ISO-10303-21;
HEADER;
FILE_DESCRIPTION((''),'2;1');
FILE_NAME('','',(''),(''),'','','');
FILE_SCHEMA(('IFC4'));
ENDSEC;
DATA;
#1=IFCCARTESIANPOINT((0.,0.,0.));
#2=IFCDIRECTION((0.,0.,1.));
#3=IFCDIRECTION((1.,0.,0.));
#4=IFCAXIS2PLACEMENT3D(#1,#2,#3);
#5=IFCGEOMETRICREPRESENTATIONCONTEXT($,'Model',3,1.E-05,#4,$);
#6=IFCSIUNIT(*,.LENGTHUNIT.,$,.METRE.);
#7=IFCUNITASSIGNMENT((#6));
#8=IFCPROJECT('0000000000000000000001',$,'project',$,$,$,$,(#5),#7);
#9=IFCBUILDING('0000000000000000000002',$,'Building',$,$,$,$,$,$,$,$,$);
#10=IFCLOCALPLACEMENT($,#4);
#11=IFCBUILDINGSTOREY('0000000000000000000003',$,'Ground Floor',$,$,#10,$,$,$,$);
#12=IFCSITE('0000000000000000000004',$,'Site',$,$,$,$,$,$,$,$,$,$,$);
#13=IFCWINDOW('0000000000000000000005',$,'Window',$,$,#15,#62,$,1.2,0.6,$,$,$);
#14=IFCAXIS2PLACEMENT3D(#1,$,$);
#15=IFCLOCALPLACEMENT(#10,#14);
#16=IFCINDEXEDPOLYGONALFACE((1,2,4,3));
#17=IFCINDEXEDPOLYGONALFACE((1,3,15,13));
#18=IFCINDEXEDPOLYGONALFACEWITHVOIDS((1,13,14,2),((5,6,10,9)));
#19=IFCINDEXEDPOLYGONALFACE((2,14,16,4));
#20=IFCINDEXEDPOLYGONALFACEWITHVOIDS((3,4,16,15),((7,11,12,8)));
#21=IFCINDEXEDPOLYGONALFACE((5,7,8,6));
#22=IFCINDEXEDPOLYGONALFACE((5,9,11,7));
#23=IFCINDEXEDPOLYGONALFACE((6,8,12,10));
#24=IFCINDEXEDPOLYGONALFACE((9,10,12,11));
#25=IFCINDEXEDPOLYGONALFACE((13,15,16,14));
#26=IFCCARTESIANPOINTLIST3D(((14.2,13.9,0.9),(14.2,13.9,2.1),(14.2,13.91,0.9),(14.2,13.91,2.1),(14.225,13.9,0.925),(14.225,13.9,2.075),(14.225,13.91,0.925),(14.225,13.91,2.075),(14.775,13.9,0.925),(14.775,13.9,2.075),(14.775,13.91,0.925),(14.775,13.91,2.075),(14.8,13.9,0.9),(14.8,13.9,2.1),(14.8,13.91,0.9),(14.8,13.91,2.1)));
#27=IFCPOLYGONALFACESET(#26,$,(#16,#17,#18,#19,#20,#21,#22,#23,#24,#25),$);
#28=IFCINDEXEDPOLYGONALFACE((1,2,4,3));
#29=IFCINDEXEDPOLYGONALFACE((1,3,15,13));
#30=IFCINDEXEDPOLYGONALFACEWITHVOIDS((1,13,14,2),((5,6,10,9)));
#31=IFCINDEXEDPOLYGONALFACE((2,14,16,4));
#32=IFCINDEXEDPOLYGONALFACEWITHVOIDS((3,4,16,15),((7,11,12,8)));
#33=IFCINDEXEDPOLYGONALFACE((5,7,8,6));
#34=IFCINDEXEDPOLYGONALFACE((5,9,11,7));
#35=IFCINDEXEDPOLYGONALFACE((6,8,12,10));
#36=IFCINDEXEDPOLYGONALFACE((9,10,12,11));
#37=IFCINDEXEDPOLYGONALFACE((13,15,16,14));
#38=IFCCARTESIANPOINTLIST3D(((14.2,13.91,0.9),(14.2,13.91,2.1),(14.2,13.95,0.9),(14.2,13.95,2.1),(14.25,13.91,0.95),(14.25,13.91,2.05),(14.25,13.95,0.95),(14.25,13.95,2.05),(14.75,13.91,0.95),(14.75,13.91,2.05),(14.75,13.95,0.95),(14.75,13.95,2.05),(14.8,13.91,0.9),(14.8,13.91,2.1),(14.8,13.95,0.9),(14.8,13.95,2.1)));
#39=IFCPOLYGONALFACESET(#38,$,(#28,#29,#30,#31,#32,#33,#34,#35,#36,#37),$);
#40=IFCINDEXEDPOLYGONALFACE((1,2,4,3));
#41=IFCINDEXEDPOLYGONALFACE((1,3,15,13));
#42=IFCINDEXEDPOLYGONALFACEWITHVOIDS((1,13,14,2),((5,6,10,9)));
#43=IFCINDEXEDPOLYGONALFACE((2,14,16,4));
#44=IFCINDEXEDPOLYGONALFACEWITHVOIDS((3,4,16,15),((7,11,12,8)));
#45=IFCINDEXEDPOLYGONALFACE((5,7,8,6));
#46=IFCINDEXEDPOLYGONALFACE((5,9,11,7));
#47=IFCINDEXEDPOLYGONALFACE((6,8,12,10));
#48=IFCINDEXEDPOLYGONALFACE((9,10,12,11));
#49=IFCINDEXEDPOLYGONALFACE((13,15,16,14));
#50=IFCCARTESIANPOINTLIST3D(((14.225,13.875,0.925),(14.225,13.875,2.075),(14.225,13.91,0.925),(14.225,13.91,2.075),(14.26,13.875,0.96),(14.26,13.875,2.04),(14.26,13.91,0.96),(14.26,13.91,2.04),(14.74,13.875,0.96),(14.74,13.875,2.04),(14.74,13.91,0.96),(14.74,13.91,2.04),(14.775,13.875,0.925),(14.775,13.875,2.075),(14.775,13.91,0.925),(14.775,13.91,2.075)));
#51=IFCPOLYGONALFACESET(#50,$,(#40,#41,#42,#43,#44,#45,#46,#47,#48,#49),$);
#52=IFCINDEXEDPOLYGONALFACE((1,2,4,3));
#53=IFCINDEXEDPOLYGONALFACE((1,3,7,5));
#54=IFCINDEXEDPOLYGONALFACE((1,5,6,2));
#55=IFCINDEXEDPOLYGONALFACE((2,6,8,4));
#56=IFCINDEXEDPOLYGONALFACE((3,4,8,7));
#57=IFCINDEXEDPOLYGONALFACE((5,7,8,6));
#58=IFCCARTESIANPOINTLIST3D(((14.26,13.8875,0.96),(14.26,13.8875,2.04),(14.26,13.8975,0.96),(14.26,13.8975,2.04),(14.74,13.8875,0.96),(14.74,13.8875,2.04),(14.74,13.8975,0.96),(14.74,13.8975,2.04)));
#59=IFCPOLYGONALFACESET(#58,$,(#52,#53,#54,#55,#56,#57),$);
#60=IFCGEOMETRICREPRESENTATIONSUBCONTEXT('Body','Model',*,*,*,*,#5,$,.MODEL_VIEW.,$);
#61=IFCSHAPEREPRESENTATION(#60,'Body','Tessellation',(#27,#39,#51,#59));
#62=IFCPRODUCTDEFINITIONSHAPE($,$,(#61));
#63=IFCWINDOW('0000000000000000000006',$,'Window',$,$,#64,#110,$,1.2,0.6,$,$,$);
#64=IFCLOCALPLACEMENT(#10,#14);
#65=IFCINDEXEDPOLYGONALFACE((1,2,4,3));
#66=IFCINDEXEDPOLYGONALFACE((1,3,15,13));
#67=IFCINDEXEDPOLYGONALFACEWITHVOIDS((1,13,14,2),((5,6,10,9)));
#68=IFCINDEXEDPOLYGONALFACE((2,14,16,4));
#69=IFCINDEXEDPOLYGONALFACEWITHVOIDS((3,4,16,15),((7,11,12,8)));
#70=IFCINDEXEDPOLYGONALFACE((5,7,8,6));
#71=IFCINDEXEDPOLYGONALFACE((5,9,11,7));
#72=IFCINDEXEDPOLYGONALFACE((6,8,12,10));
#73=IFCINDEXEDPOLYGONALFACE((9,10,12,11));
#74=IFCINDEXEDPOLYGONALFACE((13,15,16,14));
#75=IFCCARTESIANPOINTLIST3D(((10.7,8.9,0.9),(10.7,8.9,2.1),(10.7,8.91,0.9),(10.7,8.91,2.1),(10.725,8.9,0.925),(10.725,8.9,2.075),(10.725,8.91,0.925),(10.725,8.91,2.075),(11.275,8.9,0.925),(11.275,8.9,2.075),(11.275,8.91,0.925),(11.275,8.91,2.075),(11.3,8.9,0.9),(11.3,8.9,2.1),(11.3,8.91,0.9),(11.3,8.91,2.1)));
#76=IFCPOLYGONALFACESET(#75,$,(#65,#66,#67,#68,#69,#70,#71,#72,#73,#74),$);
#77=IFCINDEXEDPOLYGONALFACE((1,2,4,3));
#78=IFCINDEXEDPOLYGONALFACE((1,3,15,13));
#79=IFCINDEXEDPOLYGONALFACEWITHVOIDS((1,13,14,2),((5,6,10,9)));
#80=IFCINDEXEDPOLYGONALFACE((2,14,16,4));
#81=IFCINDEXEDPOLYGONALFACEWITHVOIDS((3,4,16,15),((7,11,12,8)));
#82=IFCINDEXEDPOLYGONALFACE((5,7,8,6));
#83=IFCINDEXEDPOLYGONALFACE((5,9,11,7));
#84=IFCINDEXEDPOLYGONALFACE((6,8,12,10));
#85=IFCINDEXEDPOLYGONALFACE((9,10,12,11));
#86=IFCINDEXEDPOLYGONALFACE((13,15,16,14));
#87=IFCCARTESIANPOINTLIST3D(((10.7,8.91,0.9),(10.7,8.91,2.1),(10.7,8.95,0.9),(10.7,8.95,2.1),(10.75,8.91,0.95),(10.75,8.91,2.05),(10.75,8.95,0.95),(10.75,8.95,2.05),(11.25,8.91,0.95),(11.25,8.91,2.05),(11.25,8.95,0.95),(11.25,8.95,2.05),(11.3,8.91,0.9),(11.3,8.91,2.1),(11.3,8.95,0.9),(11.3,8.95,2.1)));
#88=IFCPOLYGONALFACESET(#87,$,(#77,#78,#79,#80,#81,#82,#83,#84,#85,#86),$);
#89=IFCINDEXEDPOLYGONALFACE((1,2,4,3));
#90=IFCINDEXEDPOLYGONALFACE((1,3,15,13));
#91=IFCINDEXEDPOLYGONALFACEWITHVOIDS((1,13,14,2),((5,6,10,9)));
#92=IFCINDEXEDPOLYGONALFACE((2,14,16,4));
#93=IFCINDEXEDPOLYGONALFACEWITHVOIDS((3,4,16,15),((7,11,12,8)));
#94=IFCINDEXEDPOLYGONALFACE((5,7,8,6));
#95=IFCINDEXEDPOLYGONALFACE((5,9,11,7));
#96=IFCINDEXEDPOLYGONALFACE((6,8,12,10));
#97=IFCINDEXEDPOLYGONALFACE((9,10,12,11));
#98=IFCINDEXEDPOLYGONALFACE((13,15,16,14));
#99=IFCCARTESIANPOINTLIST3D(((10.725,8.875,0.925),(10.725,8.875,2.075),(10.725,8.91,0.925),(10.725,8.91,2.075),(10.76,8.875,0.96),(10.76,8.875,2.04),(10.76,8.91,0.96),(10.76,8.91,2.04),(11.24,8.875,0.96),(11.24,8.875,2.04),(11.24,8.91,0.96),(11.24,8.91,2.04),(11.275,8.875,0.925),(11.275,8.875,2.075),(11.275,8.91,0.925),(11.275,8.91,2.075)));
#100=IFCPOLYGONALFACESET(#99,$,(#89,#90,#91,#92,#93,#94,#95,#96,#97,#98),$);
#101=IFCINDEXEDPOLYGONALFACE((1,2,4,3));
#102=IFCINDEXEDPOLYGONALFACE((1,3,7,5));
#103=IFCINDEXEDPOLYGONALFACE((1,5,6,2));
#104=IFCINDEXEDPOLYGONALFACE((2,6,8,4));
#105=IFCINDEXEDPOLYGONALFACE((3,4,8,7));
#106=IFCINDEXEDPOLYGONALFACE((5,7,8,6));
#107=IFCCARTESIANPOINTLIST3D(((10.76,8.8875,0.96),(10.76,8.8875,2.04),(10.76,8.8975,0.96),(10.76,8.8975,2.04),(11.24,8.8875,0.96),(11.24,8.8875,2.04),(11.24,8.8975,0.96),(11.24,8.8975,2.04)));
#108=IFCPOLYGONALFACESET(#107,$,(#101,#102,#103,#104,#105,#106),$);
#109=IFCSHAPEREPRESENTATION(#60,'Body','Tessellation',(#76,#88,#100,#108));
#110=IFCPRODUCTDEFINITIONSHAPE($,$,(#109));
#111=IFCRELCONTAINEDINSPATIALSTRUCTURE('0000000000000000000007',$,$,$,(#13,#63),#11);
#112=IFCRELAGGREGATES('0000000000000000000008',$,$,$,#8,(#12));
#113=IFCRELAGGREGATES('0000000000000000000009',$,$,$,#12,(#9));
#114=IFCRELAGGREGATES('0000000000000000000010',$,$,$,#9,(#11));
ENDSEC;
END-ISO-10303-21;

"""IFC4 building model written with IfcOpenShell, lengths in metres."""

from ifc_helpers import new_model, si_unit, frame, origin_with_axes, place, context, subcontext, project, spatial, line, indexed_curve, outline, extrude, element, save


model = new_model("IFC4")

# Units and contexts
model_context = context("Model", 3, precision=1e-05, world=origin_with_axes())
body_context = subcontext(model_context, "Body", "Model", "MODEL_VIEW")
ifc_project = project(units=[si_unit("LENGTHUNIT", "METRE")], contexts=[model_context])

# Site, building, storey
site = spatial("IfcSite", under=ifc_project, Name="Site")
building = spatial("IfcBuilding", under=site, Name="Building")
storey_placement = place(None, origin_with_axes())
storey = spatial("IfcBuildingStorey", under=building, at=storey_placement, Name="Ground Floor")

# Windows
for number, where, z_axis, x_axis, name in (
    (1, (14.8, 14.0, 0.9), (0.0, 0.0, 1.0), (-1.0, 0.0, 0.0), "Window"),
    (2, (11.3, 9.0, 0.9), (0.0, 0.0, 1.0), (-1.0, 0.0, 0.0), "Window"),
):
    element("IfcWindow", number, at=place(storey_placement, frame(where, z_axis=z_axis, x_axis=x_axis)), inside=storey, Name=name, OverallHeight=1.2, OverallWidth=0.6, context=body_context, shape_type="SweptSolid", body=[
        extrude(outline(indexed_curve([(0.0, 0.0), (0.6, 0.0), (0.6, 1.2), (0.0, 1.2)], segments=[line(1, 2, 3, 4, 1)]), holes=[indexed_curve([(0.025, 0.025), (0.575, 0.025), (0.575, 1.175), (0.025, 1.175)], segments=[line(1, 2, 3, 4, 1)])]), frame((0.0, 0.09, 0.0), z_axis=(0.0, -1.0, 0.0), x_axis=(1.0, 0.0, 0.0)), (0.0, 0.0, -1.0), 0.01),
        extrude(outline(indexed_curve([(0.0, 0.0), (0.6, 0.0), (0.6, 1.2), (0.0, 1.2)], segments=[line(1, 2, 3, 4, 1)]), holes=[indexed_curve([(0.05, 0.05), (0.55, 0.05), (0.55, 1.15), (0.05, 1.15)], segments=[line(1, 2, 3, 4, 1)])]), frame((0.0, 0.05, 0.0), z_axis=(0.0, -1.0, 0.0), x_axis=(1.0, 0.0, 0.0)), (0.0, 0.0, -1.0), 0.04),
        extrude(outline(indexed_curve([(0.0, 0.0), (0.55, 0.0), (0.55, 1.15), (0.0, 1.15)], segments=[line(1, 2, 3, 4, 1)]), holes=[indexed_curve([(0.035, 0.035), (0.515, 0.035), (0.515, 1.115), (0.035, 1.115)], segments=[line(1, 2, 3, 4, 1)])]), frame((0.025, 0.09, 0.025), z_axis=(0.0, -1.0, 0.0), x_axis=(1.0, 0.0, 0.0)), (0.0, 0.0, -1.0), 0.035),
        extrude(outline(indexed_curve([(0.035, 0.035), (0.515, 0.035), (0.515, 1.115), (0.035, 1.115)], segments=[line(1, 2, 3, 4, 1)])), frame((0.025, 0.1025, 0.025), z_axis=(0.0, -1.0, 0.0), x_axis=(1.0, 0.0, 0.0)), (0.0, 0.0, -1.0), 0.01),
    ])

save(model, "model.ifc")
